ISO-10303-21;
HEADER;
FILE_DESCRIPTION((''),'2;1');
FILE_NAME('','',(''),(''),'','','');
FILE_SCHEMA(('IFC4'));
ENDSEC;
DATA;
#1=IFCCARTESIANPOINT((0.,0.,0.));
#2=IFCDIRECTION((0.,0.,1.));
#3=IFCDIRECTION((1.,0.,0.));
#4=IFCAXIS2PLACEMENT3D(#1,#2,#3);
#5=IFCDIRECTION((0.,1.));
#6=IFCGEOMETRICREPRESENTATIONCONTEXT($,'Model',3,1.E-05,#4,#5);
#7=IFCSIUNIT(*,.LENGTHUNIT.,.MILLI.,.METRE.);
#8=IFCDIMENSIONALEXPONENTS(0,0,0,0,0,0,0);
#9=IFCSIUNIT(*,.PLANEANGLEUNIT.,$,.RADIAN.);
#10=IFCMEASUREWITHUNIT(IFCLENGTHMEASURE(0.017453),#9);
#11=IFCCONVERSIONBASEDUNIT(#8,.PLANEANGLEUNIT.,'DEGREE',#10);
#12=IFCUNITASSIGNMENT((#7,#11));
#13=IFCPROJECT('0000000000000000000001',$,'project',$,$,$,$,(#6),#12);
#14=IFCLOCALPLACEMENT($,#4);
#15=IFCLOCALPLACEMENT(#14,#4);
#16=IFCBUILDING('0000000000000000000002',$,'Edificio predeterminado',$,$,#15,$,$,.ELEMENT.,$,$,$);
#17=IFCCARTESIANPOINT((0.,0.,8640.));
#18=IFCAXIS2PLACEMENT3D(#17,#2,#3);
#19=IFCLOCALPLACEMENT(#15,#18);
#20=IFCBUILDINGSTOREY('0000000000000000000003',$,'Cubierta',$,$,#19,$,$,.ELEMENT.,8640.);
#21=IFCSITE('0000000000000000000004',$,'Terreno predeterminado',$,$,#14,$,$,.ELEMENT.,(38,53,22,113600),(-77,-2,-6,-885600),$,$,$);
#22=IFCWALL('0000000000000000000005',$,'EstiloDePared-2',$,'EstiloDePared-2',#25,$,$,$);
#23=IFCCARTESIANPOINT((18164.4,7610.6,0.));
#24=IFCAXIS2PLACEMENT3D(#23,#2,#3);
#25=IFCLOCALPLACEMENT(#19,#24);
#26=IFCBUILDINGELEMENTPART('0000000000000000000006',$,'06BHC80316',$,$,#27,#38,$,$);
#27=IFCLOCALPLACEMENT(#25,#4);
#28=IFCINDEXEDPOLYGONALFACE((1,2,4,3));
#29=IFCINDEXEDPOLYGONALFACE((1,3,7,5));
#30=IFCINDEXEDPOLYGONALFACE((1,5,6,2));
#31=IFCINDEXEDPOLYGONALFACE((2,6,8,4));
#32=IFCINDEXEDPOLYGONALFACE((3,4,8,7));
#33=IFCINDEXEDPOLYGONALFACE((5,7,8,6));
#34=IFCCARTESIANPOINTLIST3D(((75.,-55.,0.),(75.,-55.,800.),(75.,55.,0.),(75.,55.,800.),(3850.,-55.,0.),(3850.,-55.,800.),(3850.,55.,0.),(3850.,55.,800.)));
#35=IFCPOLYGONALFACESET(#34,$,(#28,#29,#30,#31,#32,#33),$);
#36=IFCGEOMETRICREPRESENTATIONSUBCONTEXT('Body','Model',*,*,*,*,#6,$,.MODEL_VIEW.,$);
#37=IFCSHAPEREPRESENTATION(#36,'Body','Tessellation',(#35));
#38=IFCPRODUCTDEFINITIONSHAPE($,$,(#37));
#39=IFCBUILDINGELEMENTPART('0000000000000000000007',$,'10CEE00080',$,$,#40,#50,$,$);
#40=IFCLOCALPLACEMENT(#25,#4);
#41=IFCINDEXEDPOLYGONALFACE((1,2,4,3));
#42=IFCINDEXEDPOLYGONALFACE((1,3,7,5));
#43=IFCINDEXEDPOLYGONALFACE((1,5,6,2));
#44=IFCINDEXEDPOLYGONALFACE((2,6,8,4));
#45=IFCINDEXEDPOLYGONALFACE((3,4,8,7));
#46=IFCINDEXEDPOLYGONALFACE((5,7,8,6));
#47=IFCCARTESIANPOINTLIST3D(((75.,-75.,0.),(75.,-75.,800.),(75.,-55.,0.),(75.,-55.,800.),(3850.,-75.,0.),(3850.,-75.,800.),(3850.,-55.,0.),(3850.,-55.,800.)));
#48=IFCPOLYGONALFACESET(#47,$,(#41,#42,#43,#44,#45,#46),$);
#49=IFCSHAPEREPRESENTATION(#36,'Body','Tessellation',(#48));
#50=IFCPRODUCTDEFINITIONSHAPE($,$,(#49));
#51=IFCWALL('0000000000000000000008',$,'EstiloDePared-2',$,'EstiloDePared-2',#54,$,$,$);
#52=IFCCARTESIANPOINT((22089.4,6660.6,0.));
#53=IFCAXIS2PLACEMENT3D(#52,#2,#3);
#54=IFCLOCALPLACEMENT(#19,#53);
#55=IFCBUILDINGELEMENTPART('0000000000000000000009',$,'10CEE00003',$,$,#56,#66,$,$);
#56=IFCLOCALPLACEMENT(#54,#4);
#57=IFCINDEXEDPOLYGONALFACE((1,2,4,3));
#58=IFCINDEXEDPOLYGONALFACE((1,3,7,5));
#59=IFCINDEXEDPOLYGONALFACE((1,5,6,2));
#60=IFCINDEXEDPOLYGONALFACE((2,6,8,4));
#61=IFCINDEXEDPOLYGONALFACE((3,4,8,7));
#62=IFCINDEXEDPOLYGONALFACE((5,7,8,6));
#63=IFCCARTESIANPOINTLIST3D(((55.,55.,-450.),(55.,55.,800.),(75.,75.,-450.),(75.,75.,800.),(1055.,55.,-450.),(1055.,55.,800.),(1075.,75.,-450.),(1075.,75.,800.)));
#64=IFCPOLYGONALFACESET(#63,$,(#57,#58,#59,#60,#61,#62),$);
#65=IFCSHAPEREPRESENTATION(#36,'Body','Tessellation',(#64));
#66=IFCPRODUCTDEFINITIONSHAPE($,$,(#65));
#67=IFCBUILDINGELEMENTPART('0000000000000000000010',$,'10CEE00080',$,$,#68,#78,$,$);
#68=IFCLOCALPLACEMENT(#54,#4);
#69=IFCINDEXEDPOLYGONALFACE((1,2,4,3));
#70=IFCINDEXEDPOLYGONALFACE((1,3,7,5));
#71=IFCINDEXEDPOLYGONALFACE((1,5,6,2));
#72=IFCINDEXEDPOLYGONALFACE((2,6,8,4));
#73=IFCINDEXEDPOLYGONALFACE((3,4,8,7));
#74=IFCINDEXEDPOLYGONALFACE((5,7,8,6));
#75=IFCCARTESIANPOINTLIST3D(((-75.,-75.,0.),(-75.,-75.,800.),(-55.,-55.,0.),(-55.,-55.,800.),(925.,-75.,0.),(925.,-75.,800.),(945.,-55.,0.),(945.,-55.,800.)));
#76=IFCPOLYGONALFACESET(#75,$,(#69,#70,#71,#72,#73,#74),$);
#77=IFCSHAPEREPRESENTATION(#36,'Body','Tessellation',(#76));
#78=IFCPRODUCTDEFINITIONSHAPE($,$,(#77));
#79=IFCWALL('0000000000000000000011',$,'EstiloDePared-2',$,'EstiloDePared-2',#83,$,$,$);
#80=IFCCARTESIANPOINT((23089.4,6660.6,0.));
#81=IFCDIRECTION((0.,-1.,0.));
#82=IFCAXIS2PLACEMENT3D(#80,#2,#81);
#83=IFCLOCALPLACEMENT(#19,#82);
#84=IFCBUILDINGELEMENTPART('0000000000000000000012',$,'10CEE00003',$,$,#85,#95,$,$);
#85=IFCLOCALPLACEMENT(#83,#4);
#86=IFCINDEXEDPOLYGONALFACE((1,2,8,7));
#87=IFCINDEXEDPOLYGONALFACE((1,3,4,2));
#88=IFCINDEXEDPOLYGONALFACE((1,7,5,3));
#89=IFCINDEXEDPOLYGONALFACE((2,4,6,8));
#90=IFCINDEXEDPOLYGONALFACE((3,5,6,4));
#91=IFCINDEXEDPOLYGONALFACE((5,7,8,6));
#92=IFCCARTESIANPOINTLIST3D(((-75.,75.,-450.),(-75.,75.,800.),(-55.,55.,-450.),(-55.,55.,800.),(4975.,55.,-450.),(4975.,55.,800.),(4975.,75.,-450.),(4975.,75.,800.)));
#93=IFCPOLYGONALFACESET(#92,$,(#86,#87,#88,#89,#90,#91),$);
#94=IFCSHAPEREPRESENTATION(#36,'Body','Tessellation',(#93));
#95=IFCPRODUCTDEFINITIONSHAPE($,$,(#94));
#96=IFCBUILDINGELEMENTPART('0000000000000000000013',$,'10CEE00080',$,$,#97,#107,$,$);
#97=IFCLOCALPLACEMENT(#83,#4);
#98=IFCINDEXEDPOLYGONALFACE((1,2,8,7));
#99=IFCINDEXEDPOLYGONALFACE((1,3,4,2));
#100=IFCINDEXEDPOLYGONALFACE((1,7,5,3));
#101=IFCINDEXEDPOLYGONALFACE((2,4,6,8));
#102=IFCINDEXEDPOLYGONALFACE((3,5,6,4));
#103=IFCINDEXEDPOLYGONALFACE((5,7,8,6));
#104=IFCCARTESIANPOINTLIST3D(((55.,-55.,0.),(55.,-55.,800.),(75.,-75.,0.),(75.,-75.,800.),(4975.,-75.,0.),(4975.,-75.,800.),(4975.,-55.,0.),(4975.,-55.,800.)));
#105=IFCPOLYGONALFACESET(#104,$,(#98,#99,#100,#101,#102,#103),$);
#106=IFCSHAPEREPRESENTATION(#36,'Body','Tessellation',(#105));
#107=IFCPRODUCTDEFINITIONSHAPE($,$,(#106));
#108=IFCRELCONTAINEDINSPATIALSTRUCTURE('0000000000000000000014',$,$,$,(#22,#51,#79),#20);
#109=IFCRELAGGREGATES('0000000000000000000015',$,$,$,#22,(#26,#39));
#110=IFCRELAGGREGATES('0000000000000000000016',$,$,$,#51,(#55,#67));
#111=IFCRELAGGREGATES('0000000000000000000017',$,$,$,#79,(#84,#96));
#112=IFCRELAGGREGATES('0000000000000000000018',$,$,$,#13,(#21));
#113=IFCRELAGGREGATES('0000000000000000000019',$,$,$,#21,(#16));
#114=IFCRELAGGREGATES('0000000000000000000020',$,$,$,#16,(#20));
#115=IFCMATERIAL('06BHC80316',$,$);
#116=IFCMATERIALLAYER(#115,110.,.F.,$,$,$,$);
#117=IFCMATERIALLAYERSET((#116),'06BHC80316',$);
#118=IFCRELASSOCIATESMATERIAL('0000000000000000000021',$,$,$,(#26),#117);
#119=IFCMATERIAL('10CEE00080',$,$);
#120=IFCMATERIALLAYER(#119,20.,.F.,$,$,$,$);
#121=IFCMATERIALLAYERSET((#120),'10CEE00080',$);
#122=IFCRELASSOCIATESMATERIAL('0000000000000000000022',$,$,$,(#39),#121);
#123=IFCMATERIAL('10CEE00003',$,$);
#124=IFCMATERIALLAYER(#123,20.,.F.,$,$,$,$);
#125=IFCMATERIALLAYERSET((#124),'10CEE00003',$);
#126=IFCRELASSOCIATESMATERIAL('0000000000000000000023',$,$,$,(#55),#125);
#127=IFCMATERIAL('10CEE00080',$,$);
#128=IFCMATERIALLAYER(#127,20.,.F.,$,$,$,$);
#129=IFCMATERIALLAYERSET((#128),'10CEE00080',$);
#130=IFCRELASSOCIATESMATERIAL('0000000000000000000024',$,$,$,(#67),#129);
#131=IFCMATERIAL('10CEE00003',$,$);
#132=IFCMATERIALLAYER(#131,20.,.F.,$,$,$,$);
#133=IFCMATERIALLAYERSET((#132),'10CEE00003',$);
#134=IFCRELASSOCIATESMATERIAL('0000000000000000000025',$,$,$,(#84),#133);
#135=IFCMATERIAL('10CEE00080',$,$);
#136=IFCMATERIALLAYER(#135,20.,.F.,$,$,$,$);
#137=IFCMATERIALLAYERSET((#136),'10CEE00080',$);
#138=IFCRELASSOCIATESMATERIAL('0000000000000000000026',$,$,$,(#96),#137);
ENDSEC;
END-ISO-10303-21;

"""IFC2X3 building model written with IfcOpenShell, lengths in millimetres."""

from ifc_helpers import new_model, entity, si_unit, converted_unit, direction, frame, origin_with_axes, place, context, subcontext, project, spatial, polyline, outline, extrude, material, layer, layer_set, layer_usage, element, aggregate, save


model = new_model("IFC2X3")

# Units and contexts
model_context = context("Model", 3, precision=1e-05, world=origin_with_axes(), true_north=direction((0.0, 1.0)))
body_context = subcontext(model_context, "Body", "Model", "MODEL_VIEW")
ifc_project = project(units=[si_unit("LENGTHUNIT", "METRE", prefix="MILLI"), converted_unit("PLANEANGLEUNIT", "DEGREE", entity("IfcLengthMeasure", 0.017453), si_unit("PLANEANGLEUNIT", "RADIAN"), dimensions=[0, 0, 0, 0, 0, 0, 0])], contexts=[model_context])

# Site, building, storey
site_placement = place(None, origin_with_axes())
site = spatial("IfcSite", under=ifc_project, at=site_placement, Name="Terreno predeterminado", CompositionType="ELEMENT", RefLatitude=(38, 53, 22, 113600), RefLongitude=(-77, -2, -6, -885600))
building_placement = place(site_placement, origin_with_axes())
building = spatial("IfcBuilding", under=site, at=building_placement, Name="Edificio predeterminado", CompositionType="ELEMENT")
storey_placement = place(building_placement, frame((0.0, 0.0, 8640.0), z_axis=(0.0, 0.0, 1.0), x_axis=(1.0, 0.0, 0.0)))
storey = spatial("IfcBuildingStorey", under=building, at=storey_placement, Name="Cubierta", CompositionType="ELEMENT", Elevation=8640.0)

# Walls, building element parts
wall_1_placement = place(storey_placement, frame((18164.4, 7610.6, 0.0), z_axis=(0.0, 0.0, 1.0), x_axis=(1.0, 0.0, 0.0)))
wall_1 = element("IfcWall", 1, at=wall_1_placement, inside=storey, Name="EstiloDePared-2", ObjectType="EstiloDePared-2")
ifc_material_1 = material(Name="06BHC80316")
ifc_layer_1 = layer(ifc_material_1, 110.0, ventilated=False)
ifc_layer_set_1 = layer_set([ifc_layer_1], Name="06BHC80316")
ifc_layer_usage_1 = layer_usage(ifc_layer_set_1, "AXIS2", "NEGATIVE", -55.0)
building_element_part_1_placement = place(wall_1_placement, origin_with_axes())
building_element_part_1 = element("IfcBuildingElementPart", 2, at=building_element_part_1_placement, material=ifc_layer_usage_1, Name="06BHC80316", context=body_context, shape_type="SweptSolid", body=[
    extrude(outline(polyline([(3850.0, 55.0), (3850.0, -55.0), (75.0, -55.0), (75.0, 55.0), (3850.0, 55.0)])), origin_with_axes(), (0.0, 0.0, 1.0), 800.0),
])
ifc_material_2 = material(Name="10CEE00080")
ifc_layer_2 = layer(ifc_material_2, 20.0, ventilated=False)
ifc_layer_set_2 = layer_set([ifc_layer_2], Name="10CEE00080")
ifc_layer_usage_2 = layer_usage(ifc_layer_set_2, "AXIS2", "NEGATIVE", 55.0)
building_element_part_2_placement = place(wall_1_placement, origin_with_axes())
building_element_part_2 = element("IfcBuildingElementPart", 3, at=building_element_part_2_placement, material=ifc_layer_usage_2, Name="10CEE00080", context=body_context, shape_type="SweptSolid", body=[
    extrude(outline(polyline([(3850.0, -55.0), (3850.0, -75.0), (75.0, -75.0), (75.0, -55.0), (3850.0, -55.0)])), origin_with_axes(), (0.0, 0.0, 1.0), 800.0),
])
aggregate(wall_1, [building_element_part_1, building_element_part_2])
wall_2_placement = place(storey_placement, frame((22089.4, 6660.6, 0.0), z_axis=(0.0, 0.0, 1.0), x_axis=(1.0, 0.0, 0.0)))
wall_2 = element("IfcWall", 4, at=wall_2_placement, inside=storey, Name="EstiloDePared-2", ObjectType="EstiloDePared-2")
ifc_material_3 = material(Name="10CEE00003")
ifc_layer_3 = layer(ifc_material_3, 20.0, ventilated=False)
ifc_layer_set_3 = layer_set([ifc_layer_3], Name="10CEE00003")
ifc_layer_usage_3 = layer_usage(ifc_layer_set_3, "AXIS2", "NEGATIVE", -75.0)
building_element_part_3_placement = place(wall_2_placement, origin_with_axes())
building_element_part_3 = element("IfcBuildingElementPart", 5, at=building_element_part_3_placement, material=ifc_layer_usage_3, Name="10CEE00003", context=body_context, shape_type="SweptSolid", body=[
    extrude(outline(polyline([(1075.0, 75.0), (1055.0, 55.0), (55.0, 55.0), (75.0, 75.0), (1075.0, 75.0)])), frame((0.0, 0.0, -450.0), z_axis=(0.0, 0.0, 1.0), x_axis=(1.0, 0.0, 0.0)), (0.0, 0.0, 1.0), 1250.0),
])
ifc_material_4 = material(Name="10CEE00080")
ifc_layer_4 = layer(ifc_material_4, 20.0, ventilated=False)
ifc_layer_set_4 = layer_set([ifc_layer_4], Name="10CEE00080")
ifc_layer_usage_4 = layer_usage(ifc_layer_set_4, "AXIS2", "NEGATIVE", 55.0)
building_element_part_4_placement = place(wall_2_placement, origin_with_axes())
building_element_part_4 = element("IfcBuildingElementPart", 6, at=building_element_part_4_placement, material=ifc_layer_usage_4, Name="10CEE00080", context=body_context, shape_type="SweptSolid", body=[
    extrude(outline(polyline([(945.0, -55.0), (925.0, -75.0), (-75.0, -75.0), (-55.0, -55.0), (945.0, -55.0)])), origin_with_axes(), (0.0, 0.0, 1.0), 800.0),
])
aggregate(wall_2, [building_element_part_3, building_element_part_4])
wall_3_placement = place(storey_placement, frame((23089.4, 6660.6, 0.0), z_axis=(0.0, 0.0, 1.0), x_axis=(0.0, -1.0, 0.0)))
wall_3 = element("IfcWall", 7, at=wall_3_placement, inside=storey, Name="EstiloDePared-2", ObjectType="EstiloDePared-2")
ifc_material_5 = material(Name="10CEE00003")
ifc_layer_5 = layer(ifc_material_5, 20.0, ventilated=False)
ifc_layer_set_5 = layer_set([ifc_layer_5], Name="10CEE00003")
ifc_layer_usage_5 = layer_usage(ifc_layer_set_5, "AXIS2", "NEGATIVE", -75.0)
building_element_part_5_placement = place(wall_3_placement, origin_with_axes())
building_element_part_5 = element("IfcBuildingElementPart", 8, at=building_element_part_5_placement, material=ifc_layer_usage_5, Name="10CEE00003", context=body_context, shape_type="SweptSolid", body=[
    extrude(outline(polyline([(4975.0, 75.0), (4975.0, 55.0), (-55.0, 55.0), (-75.0, 75.0), (4975.0, 75.0)])), frame((0.0, 0.0, -450.0), z_axis=(0.0, 0.0, 1.0), x_axis=(1.0, 0.0, 0.0)), (0.0, 0.0, 1.0), 1250.0),
])
ifc_material_6 = material(Name="10CEE00080")
ifc_layer_6 = layer(ifc_material_6, 20.0, ventilated=False)
ifc_layer_set_6 = layer_set([ifc_layer_6], Name="10CEE00080")
ifc_layer_usage_6 = layer_usage(ifc_layer_set_6, "AXIS2", "NEGATIVE", 55.0)
building_element_part_6_placement = place(wall_3_placement, origin_with_axes())
building_element_part_6 = element("IfcBuildingElementPart", 9, at=building_element_part_6_placement, material=ifc_layer_usage_6, Name="10CEE00080", context=body_context, shape_type="SweptSolid", body=[
    extrude(outline(polyline([(4975.0, -55.0), (4975.0, -75.0), (75.0, -75.0), (55.0, -55.0), (4975.0, -55.0)])), origin_with_axes(), (0.0, 0.0, 1.0), 800.0),
])
aggregate(wall_3, [building_element_part_5, building_element_part_6])

save(model, "model.ifc")
